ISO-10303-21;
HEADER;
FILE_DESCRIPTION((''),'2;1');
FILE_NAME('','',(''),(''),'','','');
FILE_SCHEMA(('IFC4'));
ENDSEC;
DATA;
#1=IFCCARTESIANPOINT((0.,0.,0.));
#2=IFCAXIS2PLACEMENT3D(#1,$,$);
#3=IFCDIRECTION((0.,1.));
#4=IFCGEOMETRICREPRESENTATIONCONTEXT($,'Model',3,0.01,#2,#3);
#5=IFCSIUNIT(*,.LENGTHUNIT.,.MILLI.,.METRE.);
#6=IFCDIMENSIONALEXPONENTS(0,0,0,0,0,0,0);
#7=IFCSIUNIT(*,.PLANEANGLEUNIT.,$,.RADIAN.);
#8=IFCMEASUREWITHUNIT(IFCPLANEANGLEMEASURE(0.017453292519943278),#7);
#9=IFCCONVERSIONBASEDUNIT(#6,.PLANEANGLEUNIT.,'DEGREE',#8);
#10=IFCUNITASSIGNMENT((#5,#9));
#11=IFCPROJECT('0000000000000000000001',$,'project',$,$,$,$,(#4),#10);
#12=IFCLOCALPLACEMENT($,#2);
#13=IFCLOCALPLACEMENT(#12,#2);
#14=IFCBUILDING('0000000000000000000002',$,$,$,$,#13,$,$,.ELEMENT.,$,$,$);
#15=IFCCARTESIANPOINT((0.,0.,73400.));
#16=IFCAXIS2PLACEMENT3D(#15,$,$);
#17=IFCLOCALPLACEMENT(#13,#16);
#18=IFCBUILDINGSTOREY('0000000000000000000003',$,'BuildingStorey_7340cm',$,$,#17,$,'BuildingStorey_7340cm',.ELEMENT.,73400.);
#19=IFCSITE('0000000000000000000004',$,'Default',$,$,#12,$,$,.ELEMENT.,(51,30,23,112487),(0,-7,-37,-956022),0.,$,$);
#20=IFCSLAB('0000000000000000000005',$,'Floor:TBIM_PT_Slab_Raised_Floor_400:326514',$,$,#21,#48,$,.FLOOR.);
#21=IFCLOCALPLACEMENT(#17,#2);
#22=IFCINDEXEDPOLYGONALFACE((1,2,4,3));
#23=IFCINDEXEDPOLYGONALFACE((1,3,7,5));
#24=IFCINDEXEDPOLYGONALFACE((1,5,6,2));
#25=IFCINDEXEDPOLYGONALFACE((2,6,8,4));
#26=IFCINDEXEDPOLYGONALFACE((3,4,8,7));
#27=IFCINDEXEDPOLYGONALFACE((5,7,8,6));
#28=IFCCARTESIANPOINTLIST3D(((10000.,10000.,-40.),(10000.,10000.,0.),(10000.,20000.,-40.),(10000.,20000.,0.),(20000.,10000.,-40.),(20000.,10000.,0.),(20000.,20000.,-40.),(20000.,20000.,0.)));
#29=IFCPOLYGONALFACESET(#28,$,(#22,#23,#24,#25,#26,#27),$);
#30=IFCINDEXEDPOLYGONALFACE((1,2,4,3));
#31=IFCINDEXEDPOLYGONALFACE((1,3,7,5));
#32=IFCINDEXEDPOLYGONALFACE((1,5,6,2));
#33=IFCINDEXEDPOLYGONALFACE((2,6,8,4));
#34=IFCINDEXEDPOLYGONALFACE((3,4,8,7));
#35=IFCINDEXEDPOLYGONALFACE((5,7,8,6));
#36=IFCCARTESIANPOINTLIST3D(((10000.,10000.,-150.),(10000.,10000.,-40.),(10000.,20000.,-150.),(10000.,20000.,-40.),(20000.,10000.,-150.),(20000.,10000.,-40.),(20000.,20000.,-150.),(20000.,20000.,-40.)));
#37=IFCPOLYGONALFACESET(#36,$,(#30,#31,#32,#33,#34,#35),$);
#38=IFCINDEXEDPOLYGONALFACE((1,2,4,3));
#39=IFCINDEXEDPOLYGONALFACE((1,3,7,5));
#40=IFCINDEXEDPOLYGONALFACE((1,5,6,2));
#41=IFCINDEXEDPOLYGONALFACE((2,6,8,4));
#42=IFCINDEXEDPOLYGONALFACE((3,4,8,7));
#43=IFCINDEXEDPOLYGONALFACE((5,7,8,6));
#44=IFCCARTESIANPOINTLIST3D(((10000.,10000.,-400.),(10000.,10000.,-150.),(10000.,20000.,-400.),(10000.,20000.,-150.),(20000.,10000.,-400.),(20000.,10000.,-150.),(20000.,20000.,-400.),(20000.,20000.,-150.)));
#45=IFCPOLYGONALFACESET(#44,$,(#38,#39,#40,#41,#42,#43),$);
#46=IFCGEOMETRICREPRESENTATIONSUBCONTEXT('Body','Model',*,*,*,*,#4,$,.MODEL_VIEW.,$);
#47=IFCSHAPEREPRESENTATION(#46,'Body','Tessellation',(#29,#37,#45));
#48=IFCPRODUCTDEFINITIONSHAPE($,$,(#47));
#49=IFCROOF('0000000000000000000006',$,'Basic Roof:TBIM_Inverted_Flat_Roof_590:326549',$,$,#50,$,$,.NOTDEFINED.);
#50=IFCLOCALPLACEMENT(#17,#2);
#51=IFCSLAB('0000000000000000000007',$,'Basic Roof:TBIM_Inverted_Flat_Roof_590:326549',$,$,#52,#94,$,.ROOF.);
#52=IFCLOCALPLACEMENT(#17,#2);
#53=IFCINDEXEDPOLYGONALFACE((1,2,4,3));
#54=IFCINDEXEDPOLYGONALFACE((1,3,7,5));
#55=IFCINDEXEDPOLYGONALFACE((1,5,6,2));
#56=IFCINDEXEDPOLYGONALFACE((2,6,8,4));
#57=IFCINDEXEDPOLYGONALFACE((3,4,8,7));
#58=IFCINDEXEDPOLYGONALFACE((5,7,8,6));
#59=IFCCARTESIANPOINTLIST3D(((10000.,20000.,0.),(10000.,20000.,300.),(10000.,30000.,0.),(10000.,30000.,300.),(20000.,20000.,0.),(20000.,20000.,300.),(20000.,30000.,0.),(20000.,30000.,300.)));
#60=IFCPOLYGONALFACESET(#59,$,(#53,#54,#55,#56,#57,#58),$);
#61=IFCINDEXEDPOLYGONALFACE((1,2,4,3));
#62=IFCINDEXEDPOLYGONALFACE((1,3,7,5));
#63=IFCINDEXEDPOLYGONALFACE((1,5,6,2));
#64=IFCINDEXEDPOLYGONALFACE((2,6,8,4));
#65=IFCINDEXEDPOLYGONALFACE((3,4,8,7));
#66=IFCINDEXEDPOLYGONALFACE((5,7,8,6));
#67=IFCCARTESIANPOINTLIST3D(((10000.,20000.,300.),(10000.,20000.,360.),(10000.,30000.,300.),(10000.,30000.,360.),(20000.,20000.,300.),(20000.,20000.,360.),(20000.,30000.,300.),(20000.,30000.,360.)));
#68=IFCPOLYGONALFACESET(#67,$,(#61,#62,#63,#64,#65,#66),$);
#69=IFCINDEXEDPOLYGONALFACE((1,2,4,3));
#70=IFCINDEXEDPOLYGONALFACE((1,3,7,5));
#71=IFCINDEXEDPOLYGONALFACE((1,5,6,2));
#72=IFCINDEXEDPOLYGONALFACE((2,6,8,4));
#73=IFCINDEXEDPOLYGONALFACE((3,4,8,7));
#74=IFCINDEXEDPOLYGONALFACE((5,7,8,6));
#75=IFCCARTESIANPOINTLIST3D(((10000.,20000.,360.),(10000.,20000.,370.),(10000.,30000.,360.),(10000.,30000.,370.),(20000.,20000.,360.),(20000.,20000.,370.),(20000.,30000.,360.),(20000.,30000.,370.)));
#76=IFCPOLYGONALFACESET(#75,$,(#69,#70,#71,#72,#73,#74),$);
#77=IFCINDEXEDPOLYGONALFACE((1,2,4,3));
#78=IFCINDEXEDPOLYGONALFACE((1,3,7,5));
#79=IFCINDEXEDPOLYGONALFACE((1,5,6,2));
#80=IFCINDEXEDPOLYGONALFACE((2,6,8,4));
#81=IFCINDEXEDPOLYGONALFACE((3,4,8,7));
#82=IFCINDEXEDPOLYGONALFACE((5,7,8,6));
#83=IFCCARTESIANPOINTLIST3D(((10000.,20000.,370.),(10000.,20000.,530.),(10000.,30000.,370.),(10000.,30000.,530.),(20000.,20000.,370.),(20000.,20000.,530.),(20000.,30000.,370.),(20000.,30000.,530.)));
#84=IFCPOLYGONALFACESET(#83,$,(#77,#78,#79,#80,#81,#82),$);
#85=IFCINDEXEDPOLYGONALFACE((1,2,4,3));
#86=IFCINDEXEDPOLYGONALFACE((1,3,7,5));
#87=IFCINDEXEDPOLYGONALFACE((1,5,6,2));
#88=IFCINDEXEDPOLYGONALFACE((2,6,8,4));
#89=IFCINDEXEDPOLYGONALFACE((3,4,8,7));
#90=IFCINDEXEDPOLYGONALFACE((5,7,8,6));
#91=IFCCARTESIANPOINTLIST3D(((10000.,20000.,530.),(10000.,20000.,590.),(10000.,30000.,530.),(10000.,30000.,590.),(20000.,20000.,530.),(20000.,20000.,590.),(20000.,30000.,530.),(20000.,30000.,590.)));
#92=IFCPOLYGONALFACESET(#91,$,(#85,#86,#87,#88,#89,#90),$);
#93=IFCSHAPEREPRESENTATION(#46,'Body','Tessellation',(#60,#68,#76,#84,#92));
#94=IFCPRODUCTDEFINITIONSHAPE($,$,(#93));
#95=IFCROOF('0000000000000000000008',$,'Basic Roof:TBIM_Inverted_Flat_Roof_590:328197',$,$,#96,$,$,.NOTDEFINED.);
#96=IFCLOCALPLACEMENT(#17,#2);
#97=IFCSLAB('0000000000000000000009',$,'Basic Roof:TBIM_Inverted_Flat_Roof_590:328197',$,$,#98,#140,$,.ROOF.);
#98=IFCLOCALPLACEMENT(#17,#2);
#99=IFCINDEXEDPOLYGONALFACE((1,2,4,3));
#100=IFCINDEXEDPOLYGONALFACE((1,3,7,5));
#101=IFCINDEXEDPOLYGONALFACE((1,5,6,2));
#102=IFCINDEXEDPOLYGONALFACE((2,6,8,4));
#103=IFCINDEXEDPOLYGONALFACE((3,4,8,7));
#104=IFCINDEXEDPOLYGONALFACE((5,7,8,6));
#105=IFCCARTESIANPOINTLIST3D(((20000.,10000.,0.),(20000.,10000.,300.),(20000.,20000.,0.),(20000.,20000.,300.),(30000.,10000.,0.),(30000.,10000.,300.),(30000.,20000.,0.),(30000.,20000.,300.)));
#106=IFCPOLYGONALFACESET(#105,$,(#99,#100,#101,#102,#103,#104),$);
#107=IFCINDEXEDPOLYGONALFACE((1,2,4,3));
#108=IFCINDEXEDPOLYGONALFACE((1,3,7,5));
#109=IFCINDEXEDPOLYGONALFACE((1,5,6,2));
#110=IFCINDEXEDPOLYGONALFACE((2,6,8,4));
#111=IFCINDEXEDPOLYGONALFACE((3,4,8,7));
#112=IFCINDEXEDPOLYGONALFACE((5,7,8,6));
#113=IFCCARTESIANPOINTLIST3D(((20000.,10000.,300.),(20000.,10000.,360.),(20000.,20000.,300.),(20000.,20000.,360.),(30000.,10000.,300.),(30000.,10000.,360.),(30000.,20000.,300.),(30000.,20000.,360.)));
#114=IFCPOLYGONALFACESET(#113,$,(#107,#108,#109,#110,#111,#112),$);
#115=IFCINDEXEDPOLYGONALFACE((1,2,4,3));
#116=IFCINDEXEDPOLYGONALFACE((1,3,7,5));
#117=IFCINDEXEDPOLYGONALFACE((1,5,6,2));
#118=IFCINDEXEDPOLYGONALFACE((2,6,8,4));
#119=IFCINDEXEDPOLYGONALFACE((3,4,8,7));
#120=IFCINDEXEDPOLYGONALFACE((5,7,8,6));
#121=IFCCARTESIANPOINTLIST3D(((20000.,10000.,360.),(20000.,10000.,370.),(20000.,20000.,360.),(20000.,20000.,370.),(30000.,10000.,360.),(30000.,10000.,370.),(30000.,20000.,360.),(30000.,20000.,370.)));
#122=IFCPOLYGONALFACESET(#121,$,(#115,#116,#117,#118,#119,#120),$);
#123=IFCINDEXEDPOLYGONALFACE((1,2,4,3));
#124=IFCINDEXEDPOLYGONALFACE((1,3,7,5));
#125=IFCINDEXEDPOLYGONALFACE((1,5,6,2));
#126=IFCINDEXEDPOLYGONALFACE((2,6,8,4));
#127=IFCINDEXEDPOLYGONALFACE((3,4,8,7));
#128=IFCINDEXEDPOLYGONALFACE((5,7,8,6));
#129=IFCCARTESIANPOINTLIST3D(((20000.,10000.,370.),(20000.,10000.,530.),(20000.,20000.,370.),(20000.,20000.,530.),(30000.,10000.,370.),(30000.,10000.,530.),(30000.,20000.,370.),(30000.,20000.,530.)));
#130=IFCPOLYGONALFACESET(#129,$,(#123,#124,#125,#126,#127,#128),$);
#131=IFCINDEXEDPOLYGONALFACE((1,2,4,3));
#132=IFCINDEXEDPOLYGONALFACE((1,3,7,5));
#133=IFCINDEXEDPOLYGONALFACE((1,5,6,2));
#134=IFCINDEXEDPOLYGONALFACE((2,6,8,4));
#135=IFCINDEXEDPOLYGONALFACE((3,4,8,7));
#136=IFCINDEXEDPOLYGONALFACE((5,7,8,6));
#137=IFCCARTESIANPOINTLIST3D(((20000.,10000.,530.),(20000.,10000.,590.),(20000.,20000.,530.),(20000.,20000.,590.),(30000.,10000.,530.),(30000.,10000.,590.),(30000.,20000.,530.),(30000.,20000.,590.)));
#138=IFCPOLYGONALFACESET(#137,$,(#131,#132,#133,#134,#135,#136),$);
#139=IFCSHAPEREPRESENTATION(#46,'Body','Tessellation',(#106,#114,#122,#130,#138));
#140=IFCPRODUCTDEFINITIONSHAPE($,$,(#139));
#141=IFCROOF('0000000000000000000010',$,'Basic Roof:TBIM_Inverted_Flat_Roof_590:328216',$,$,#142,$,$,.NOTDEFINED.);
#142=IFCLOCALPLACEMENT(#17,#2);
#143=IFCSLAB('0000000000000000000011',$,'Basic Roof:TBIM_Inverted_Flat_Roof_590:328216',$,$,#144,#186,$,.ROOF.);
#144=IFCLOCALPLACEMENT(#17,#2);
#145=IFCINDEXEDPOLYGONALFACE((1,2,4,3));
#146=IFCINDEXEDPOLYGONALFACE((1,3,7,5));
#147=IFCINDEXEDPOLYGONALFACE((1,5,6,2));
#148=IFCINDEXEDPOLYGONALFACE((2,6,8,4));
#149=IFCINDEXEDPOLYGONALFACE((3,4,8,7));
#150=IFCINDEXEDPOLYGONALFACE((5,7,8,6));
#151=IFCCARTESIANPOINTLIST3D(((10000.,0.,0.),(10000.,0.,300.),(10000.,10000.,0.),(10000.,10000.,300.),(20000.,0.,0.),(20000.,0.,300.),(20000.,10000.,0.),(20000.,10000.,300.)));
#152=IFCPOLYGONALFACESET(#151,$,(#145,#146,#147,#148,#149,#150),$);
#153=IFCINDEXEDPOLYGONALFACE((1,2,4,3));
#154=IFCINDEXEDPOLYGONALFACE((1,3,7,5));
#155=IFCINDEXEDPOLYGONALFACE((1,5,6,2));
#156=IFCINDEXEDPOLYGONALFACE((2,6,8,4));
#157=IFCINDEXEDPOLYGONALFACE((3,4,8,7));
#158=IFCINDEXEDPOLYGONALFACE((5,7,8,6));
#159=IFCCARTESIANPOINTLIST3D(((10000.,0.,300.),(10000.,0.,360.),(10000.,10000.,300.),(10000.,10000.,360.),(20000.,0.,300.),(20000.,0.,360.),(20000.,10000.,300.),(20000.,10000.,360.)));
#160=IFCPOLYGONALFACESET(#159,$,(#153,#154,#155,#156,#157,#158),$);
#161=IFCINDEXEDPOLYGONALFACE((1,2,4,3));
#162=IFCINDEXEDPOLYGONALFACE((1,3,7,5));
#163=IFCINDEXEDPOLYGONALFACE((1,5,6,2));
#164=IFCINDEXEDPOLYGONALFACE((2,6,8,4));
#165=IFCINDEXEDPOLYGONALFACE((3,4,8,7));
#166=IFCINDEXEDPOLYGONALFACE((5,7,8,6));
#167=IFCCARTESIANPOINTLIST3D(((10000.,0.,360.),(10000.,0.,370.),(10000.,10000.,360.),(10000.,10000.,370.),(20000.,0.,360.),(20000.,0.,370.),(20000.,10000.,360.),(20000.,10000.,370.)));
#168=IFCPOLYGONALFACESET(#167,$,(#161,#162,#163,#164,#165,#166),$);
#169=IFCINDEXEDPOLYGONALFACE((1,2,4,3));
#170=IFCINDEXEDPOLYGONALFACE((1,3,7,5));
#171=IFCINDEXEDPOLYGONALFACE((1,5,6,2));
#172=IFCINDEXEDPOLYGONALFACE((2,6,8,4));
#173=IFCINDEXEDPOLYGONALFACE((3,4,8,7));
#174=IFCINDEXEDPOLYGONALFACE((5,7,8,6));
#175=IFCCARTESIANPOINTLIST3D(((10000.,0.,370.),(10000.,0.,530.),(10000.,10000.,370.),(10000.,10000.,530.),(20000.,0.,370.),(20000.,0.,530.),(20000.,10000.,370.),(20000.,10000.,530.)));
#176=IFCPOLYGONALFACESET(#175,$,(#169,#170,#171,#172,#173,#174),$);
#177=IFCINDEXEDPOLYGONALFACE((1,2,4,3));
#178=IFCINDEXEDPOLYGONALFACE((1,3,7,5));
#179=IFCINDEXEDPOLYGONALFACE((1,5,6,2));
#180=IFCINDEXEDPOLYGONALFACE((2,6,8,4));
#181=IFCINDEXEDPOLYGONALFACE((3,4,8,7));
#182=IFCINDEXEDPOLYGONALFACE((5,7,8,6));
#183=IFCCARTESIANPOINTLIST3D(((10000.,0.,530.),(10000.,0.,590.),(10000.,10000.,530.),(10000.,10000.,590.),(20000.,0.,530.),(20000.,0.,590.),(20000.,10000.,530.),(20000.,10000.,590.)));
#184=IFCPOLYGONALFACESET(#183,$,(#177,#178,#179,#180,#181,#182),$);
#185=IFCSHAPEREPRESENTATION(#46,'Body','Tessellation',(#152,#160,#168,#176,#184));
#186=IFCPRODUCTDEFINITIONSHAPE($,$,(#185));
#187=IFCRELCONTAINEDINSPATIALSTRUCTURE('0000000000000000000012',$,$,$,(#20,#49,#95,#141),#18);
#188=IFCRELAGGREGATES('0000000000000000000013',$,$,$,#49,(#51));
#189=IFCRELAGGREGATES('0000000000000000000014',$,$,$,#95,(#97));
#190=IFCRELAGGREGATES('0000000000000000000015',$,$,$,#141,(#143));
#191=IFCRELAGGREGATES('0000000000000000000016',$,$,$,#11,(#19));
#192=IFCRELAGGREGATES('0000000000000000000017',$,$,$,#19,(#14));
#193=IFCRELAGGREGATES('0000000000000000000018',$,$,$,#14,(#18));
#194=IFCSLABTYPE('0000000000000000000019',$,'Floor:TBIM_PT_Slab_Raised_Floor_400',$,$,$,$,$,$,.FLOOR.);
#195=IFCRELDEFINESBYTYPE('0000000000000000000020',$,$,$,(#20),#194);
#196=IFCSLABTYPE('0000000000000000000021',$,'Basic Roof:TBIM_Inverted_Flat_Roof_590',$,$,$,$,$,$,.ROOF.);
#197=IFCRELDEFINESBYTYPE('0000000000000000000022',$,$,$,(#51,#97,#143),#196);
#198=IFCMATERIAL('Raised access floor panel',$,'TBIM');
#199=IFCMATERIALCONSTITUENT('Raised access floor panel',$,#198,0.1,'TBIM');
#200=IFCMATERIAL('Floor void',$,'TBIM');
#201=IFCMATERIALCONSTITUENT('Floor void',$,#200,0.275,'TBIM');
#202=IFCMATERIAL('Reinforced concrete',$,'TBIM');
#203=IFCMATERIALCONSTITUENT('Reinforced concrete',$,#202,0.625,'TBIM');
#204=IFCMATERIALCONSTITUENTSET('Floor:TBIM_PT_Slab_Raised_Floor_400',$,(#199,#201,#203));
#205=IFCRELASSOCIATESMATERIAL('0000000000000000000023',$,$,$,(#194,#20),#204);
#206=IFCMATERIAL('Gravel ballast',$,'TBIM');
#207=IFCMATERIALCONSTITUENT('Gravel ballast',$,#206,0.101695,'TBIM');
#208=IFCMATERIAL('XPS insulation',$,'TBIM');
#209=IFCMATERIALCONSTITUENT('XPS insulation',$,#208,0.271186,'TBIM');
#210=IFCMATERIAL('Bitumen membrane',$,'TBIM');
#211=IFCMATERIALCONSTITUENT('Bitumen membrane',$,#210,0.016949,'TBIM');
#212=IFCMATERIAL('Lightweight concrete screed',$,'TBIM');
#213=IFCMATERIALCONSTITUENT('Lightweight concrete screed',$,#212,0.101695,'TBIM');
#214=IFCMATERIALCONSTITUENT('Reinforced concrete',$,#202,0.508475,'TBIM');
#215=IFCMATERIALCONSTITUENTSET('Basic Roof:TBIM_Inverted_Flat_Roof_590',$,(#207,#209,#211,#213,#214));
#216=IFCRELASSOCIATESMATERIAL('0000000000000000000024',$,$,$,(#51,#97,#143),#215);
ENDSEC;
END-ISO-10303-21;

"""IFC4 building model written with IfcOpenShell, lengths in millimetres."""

from ifc_helpers import new_model, entity, si_unit, converted_unit, direction, frame, origin, place, context, subcontext, project, spatial, indexed_curve, outline, extrude, material, constituent, constituent_set, type_object, element, aggregate, save


model = new_model("IFC4")

# Units and contexts
model_context = context("Model", 3, precision=0.01, world=origin(), true_north=direction((0.0, 1.0)))
body_context = subcontext(model_context, "Body", "Model", "MODEL_VIEW")
ifc_project = project(units=[si_unit("LENGTHUNIT", "METRE", prefix="MILLI"), converted_unit("PLANEANGLEUNIT", "DEGREE", entity("IfcPlaneAngleMeasure", 0.017453292519943278), si_unit("PLANEANGLEUNIT", "RADIAN"), dimensions=[0, 0, 0, 0, 0, 0, 0])], contexts=[model_context])

# Site, building, storey
site_placement = place(None, origin())
site = spatial("IfcSite", under=ifc_project, at=site_placement, Name="Default", CompositionType="ELEMENT", RefLatitude=(51, 30, 23, 112487), RefLongitude=(0, -7, -37, -956022), RefElevation=0.0)
building_placement = place(site_placement, origin())
building = spatial("IfcBuilding", under=site, at=building_placement, CompositionType="ELEMENT")
storey_placement = place(building_placement, frame((0.0, 0.0, 73400.0)))
storey = spatial("IfcBuildingStorey", under=building, at=storey_placement, Name="BuildingStorey_7340cm", LongName="BuildingStorey_7340cm", CompositionType="ELEMENT", Elevation=73400.0)

# Slab
ifc_material_1 = material(Name="Raised access floor panel", Category="TBIM")
ifc_constituent_1 = constituent(ifc_material_1, Name="Raised access floor panel", Category="TBIM", fraction=0.1)
ifc_material_2 = material(Name="Floor void", Category="TBIM")
ifc_constituent_2 = constituent(ifc_material_2, Name="Floor void", Category="TBIM", fraction=0.275)
ifc_material_3 = material(Name="Reinforced concrete", Category="TBIM")
ifc_constituent_3 = constituent(ifc_material_3, Name="Reinforced concrete", Category="TBIM", fraction=0.625)
ifc_constituent_set_1 = constituent_set(constituents=[ifc_constituent_1, ifc_constituent_2, ifc_constituent_3], Name="Floor:TBIM_PT_Slab_Raised_Floor_400")
slab_type_1 = type_object("IfcSlabType", Name="Floor:TBIM_PT_Slab_Raised_Floor_400", PredefinedType="FLOOR", material=ifc_constituent_set_1)
slab_1_placement = place(storey_placement, origin())
element("IfcSlab", 1, at=slab_1_placement, inside=storey, type_object=slab_type_1, material=ifc_constituent_set_1, Name="Floor:TBIM_PT_Slab_Raised_Floor_400:326514", PredefinedType="FLOOR", context=body_context, shape_type="SweptSolid", body=[
    extrude(outline(indexed_curve([(-5000.0, -5000.0), (5000.0, -5000.0), (5000.0, 5000.0), (-5000.0, 5000.0), (-5000.0, -5000.0)], self_intersect=False)), frame((15000.0, 15000.0, -40.0), z_axis=(0.0, 0.0, 1.0), x_axis=(-1.0, 0.0, 0.0)), (0.0, 0.0, 1.0), 40.0),
    extrude(outline(indexed_curve([(-5000.0, -5000.0), (5000.0, -5000.0), (5000.0, 5000.0), (-5000.0, 5000.0), (-5000.0, -5000.0)], self_intersect=False)), frame((15000.0, 15000.0, -150.0), z_axis=(0.0, 0.0, 1.0), x_axis=(-1.0, 0.0, 0.0)), (0.0, 0.0, 1.0), 110.0),
    extrude(outline(indexed_curve([(-5000.0, -5000.0), (5000.0, -5000.0), (5000.0, 5000.0), (-5000.0, 5000.0), (-5000.0, -5000.0)], self_intersect=False)), frame((15000.0, 15000.0, -400.0), z_axis=(0.0, 0.0, 1.0), x_axis=(-1.0, 0.0, 0.0)), (0.0, 0.0, 1.0), 250.0),
])

# Roofs, slabs
roof_1_placement = place(storey_placement, frame((10000.0, 20000.0, 0.0)))
roof_1 = element("IfcRoof", 2, at=roof_1_placement, inside=storey, Name="Basic Roof:TBIM_Inverted_Flat_Roof_590:326549", PredefinedType="NOTDEFINED")
ifc_material_4 = material(Name="Gravel ballast", Category="TBIM")
ifc_constituent_4 = constituent(ifc_material_4, Name="Gravel ballast", Category="TBIM", fraction=0.101695)
ifc_material_5 = material(Name="XPS insulation", Category="TBIM")
ifc_constituent_5 = constituent(ifc_material_5, Name="XPS insulation", Category="TBIM", fraction=0.271186)
ifc_material_6 = material(Name="Bitumen membrane", Category="TBIM")
ifc_constituent_6 = constituent(ifc_material_6, Name="Bitumen membrane", Category="TBIM", fraction=0.016949)
ifc_material_7 = material(Name="Lightweight concrete screed", Category="TBIM")
ifc_constituent_7 = constituent(ifc_material_7, Name="Lightweight concrete screed", Category="TBIM", fraction=0.101695)
ifc_constituent_8 = constituent(ifc_material_3, Name="Reinforced concrete", Category="TBIM", fraction=0.508475)
ifc_constituent_set_2 = constituent_set(constituents=[ifc_constituent_4, ifc_constituent_5, ifc_constituent_6, ifc_constituent_7, ifc_constituent_8], Name="Basic Roof:TBIM_Inverted_Flat_Roof_590")
slab_type_2 = type_object("IfcSlabType", Name="Basic Roof:TBIM_Inverted_Flat_Roof_590", PredefinedType="ROOF")
slab_2_placement = place(roof_1_placement, origin())
slab_2 = element("IfcSlab", 3, at=slab_2_placement, type_object=slab_type_2, material=ifc_constituent_set_2, Name="Basic Roof:TBIM_Inverted_Flat_Roof_590:326549", PredefinedType="ROOF", context=body_context, shape_type="SweptSolid", body=[
    extrude(outline(indexed_curve([(-5000.0, 5000.0), (-5000.0, -5000.0), (5000.0, -5000.0), (5000.0, 5000.0), (-5000.0, 5000.0)], self_intersect=False)), frame((5000.0, 5000.0, 0.0)), (0.0, 0.0, 1.0), 300.0),
    extrude(outline(indexed_curve([(-5000.0, 5000.0), (-5000.0, -5000.0), (5000.0, -5000.0), (5000.0, 5000.0), (-5000.0, 5000.0)], self_intersect=False)), frame((5000.0, 5000.0, 300.0)), (0.0, 0.0, 1.0), 60.0),
    extrude(outline(indexed_curve([(-5000.0, 5000.0), (-5000.0, -5000.0), (5000.0, -5000.0), (5000.0, 5000.0), (-5000.0, 5000.0)], self_intersect=False)), frame((5000.0, 5000.0, 360.0)), (0.0, 0.0, 1.0), 10.0),
    extrude(outline(indexed_curve([(-5000.0, 5000.0), (-5000.0, -5000.0), (5000.0, -5000.0), (5000.0, 5000.0), (-5000.0, 5000.0)], self_intersect=False)), frame((5000.0, 5000.0, 370.0)), (0.0, 0.0, 1.0), 160.0),
    extrude(outline(indexed_curve([(-5000.0, 5000.0), (-5000.0, -5000.0), (5000.0, -5000.0), (5000.0, 5000.0), (-5000.0, 5000.0)], self_intersect=False)), frame((5000.0, 5000.0, 530.0)), (0.0, 0.0, 1.0), 60.0),
])
aggregate(roof_1, [slab_2])
roof_2_placement = place(storey_placement, frame((20000.0, 10000.0, 0.0)))
roof_2 = element("IfcRoof", 4, at=roof_2_placement, inside=storey, Name="Basic Roof:TBIM_Inverted_Flat_Roof_590:328197", PredefinedType="NOTDEFINED")
slab_3_placement = place(roof_2_placement, origin())
slab_3 = element("IfcSlab", 5, at=slab_3_placement, type_object=slab_type_2, material=ifc_constituent_set_2, Name="Basic Roof:TBIM_Inverted_Flat_Roof_590:328197", PredefinedType="ROOF", context=body_context, shape_type="SweptSolid", body=[
    extrude(outline(indexed_curve([(-5000.0, 5000.0), (-5000.0, -5000.0), (5000.0, -5000.0), (5000.0, 5000.0), (-5000.0, 5000.0)], self_intersect=False)), frame((5000.0, 5000.0, 0.0)), (0.0, 0.0, 1.0), 300.0),
    extrude(outline(indexed_curve([(-5000.0, 5000.0), (-5000.0, -5000.0), (5000.0, -5000.0), (5000.0, 5000.0), (-5000.0, 5000.0)], self_intersect=False)), frame((5000.0, 5000.0, 300.0)), (0.0, 0.0, 1.0), 60.0),
    extrude(outline(indexed_curve([(-5000.0, 5000.0), (-5000.0, -5000.0), (5000.0, -5000.0), (5000.0, 5000.0), (-5000.0, 5000.0)], self_intersect=False)), frame((5000.0, 5000.0, 360.0)), (0.0, 0.0, 1.0), 10.0),
    extrude(outline(indexed_curve([(-5000.0, 5000.0), (-5000.0, -5000.0), (5000.0, -5000.0), (5000.0, 5000.0), (-5000.0, 5000.0)], self_intersect=False)), frame((5000.0, 5000.0, 370.0)), (0.0, 0.0, 1.0), 160.0),
    extrude(outline(indexed_curve([(-5000.0, 5000.0), (-5000.0, -5000.0), (5000.0, -5000.0), (5000.0, 5000.0), (-5000.0, 5000.0)], self_intersect=False)), frame((5000.0, 5000.0, 530.0)), (0.0, 0.0, 1.0), 60.0),
])
aggregate(roof_2, [slab_3])
roof_3_placement = place(storey_placement, frame((10000.0, 0.0, 0.0)))
roof_3 = element("IfcRoof", 6, at=roof_3_placement, inside=storey, Name="Basic Roof:TBIM_Inverted_Flat_Roof_590:328216", PredefinedType="NOTDEFINED")
slab_4_placement = place(roof_3_placement, origin())
slab_4 = element("IfcSlab", 7, at=slab_4_placement, type_object=slab_type_2, material=ifc_constituent_set_2, Name="Basic Roof:TBIM_Inverted_Flat_Roof_590:328216", PredefinedType="ROOF", context=body_context, shape_type="SweptSolid", body=[
    extrude(outline(indexed_curve([(5000.0, 5000.0), (-5000.0, 5000.0), (-5000.0, -5000.0), (5000.0, -5000.0), (5000.0, 5000.0)], self_intersect=False)), frame((5000.0, 5000.0, 0.0)), (0.0, 0.0, 1.0), 300.0),
    extrude(outline(indexed_curve([(5000.0, 5000.0), (-5000.0, 5000.0), (-5000.0, -5000.0), (5000.0, -5000.0), (5000.0, 5000.0)], self_intersect=False)), frame((5000.0, 5000.0, 300.0)), (0.0, 0.0, 1.0), 60.0),
    extrude(outline(indexed_curve([(5000.0, 5000.0), (-5000.0, 5000.0), (-5000.0, -5000.0), (5000.0, -5000.0), (5000.0, 5000.0)], self_intersect=False)), frame((5000.0, 5000.0, 360.0)), (0.0, 0.0, 1.0), 10.0),
    extrude(outline(indexed_curve([(5000.0, 5000.0), (-5000.0, 5000.0), (-5000.0, -5000.0), (5000.0, -5000.0), (5000.0, 5000.0)], self_intersect=False)), frame((5000.0, 5000.0, 370.0)), (0.0, 0.0, 1.0), 160.0),
    extrude(outline(indexed_curve([(5000.0, 5000.0), (-5000.0, 5000.0), (-5000.0, -5000.0), (5000.0, -5000.0), (5000.0, 5000.0)], self_intersect=False)), frame((5000.0, 5000.0, 530.0)), (0.0, 0.0, 1.0), 60.0),
])
aggregate(roof_3, [slab_4])

save(model, "model.ifc")
